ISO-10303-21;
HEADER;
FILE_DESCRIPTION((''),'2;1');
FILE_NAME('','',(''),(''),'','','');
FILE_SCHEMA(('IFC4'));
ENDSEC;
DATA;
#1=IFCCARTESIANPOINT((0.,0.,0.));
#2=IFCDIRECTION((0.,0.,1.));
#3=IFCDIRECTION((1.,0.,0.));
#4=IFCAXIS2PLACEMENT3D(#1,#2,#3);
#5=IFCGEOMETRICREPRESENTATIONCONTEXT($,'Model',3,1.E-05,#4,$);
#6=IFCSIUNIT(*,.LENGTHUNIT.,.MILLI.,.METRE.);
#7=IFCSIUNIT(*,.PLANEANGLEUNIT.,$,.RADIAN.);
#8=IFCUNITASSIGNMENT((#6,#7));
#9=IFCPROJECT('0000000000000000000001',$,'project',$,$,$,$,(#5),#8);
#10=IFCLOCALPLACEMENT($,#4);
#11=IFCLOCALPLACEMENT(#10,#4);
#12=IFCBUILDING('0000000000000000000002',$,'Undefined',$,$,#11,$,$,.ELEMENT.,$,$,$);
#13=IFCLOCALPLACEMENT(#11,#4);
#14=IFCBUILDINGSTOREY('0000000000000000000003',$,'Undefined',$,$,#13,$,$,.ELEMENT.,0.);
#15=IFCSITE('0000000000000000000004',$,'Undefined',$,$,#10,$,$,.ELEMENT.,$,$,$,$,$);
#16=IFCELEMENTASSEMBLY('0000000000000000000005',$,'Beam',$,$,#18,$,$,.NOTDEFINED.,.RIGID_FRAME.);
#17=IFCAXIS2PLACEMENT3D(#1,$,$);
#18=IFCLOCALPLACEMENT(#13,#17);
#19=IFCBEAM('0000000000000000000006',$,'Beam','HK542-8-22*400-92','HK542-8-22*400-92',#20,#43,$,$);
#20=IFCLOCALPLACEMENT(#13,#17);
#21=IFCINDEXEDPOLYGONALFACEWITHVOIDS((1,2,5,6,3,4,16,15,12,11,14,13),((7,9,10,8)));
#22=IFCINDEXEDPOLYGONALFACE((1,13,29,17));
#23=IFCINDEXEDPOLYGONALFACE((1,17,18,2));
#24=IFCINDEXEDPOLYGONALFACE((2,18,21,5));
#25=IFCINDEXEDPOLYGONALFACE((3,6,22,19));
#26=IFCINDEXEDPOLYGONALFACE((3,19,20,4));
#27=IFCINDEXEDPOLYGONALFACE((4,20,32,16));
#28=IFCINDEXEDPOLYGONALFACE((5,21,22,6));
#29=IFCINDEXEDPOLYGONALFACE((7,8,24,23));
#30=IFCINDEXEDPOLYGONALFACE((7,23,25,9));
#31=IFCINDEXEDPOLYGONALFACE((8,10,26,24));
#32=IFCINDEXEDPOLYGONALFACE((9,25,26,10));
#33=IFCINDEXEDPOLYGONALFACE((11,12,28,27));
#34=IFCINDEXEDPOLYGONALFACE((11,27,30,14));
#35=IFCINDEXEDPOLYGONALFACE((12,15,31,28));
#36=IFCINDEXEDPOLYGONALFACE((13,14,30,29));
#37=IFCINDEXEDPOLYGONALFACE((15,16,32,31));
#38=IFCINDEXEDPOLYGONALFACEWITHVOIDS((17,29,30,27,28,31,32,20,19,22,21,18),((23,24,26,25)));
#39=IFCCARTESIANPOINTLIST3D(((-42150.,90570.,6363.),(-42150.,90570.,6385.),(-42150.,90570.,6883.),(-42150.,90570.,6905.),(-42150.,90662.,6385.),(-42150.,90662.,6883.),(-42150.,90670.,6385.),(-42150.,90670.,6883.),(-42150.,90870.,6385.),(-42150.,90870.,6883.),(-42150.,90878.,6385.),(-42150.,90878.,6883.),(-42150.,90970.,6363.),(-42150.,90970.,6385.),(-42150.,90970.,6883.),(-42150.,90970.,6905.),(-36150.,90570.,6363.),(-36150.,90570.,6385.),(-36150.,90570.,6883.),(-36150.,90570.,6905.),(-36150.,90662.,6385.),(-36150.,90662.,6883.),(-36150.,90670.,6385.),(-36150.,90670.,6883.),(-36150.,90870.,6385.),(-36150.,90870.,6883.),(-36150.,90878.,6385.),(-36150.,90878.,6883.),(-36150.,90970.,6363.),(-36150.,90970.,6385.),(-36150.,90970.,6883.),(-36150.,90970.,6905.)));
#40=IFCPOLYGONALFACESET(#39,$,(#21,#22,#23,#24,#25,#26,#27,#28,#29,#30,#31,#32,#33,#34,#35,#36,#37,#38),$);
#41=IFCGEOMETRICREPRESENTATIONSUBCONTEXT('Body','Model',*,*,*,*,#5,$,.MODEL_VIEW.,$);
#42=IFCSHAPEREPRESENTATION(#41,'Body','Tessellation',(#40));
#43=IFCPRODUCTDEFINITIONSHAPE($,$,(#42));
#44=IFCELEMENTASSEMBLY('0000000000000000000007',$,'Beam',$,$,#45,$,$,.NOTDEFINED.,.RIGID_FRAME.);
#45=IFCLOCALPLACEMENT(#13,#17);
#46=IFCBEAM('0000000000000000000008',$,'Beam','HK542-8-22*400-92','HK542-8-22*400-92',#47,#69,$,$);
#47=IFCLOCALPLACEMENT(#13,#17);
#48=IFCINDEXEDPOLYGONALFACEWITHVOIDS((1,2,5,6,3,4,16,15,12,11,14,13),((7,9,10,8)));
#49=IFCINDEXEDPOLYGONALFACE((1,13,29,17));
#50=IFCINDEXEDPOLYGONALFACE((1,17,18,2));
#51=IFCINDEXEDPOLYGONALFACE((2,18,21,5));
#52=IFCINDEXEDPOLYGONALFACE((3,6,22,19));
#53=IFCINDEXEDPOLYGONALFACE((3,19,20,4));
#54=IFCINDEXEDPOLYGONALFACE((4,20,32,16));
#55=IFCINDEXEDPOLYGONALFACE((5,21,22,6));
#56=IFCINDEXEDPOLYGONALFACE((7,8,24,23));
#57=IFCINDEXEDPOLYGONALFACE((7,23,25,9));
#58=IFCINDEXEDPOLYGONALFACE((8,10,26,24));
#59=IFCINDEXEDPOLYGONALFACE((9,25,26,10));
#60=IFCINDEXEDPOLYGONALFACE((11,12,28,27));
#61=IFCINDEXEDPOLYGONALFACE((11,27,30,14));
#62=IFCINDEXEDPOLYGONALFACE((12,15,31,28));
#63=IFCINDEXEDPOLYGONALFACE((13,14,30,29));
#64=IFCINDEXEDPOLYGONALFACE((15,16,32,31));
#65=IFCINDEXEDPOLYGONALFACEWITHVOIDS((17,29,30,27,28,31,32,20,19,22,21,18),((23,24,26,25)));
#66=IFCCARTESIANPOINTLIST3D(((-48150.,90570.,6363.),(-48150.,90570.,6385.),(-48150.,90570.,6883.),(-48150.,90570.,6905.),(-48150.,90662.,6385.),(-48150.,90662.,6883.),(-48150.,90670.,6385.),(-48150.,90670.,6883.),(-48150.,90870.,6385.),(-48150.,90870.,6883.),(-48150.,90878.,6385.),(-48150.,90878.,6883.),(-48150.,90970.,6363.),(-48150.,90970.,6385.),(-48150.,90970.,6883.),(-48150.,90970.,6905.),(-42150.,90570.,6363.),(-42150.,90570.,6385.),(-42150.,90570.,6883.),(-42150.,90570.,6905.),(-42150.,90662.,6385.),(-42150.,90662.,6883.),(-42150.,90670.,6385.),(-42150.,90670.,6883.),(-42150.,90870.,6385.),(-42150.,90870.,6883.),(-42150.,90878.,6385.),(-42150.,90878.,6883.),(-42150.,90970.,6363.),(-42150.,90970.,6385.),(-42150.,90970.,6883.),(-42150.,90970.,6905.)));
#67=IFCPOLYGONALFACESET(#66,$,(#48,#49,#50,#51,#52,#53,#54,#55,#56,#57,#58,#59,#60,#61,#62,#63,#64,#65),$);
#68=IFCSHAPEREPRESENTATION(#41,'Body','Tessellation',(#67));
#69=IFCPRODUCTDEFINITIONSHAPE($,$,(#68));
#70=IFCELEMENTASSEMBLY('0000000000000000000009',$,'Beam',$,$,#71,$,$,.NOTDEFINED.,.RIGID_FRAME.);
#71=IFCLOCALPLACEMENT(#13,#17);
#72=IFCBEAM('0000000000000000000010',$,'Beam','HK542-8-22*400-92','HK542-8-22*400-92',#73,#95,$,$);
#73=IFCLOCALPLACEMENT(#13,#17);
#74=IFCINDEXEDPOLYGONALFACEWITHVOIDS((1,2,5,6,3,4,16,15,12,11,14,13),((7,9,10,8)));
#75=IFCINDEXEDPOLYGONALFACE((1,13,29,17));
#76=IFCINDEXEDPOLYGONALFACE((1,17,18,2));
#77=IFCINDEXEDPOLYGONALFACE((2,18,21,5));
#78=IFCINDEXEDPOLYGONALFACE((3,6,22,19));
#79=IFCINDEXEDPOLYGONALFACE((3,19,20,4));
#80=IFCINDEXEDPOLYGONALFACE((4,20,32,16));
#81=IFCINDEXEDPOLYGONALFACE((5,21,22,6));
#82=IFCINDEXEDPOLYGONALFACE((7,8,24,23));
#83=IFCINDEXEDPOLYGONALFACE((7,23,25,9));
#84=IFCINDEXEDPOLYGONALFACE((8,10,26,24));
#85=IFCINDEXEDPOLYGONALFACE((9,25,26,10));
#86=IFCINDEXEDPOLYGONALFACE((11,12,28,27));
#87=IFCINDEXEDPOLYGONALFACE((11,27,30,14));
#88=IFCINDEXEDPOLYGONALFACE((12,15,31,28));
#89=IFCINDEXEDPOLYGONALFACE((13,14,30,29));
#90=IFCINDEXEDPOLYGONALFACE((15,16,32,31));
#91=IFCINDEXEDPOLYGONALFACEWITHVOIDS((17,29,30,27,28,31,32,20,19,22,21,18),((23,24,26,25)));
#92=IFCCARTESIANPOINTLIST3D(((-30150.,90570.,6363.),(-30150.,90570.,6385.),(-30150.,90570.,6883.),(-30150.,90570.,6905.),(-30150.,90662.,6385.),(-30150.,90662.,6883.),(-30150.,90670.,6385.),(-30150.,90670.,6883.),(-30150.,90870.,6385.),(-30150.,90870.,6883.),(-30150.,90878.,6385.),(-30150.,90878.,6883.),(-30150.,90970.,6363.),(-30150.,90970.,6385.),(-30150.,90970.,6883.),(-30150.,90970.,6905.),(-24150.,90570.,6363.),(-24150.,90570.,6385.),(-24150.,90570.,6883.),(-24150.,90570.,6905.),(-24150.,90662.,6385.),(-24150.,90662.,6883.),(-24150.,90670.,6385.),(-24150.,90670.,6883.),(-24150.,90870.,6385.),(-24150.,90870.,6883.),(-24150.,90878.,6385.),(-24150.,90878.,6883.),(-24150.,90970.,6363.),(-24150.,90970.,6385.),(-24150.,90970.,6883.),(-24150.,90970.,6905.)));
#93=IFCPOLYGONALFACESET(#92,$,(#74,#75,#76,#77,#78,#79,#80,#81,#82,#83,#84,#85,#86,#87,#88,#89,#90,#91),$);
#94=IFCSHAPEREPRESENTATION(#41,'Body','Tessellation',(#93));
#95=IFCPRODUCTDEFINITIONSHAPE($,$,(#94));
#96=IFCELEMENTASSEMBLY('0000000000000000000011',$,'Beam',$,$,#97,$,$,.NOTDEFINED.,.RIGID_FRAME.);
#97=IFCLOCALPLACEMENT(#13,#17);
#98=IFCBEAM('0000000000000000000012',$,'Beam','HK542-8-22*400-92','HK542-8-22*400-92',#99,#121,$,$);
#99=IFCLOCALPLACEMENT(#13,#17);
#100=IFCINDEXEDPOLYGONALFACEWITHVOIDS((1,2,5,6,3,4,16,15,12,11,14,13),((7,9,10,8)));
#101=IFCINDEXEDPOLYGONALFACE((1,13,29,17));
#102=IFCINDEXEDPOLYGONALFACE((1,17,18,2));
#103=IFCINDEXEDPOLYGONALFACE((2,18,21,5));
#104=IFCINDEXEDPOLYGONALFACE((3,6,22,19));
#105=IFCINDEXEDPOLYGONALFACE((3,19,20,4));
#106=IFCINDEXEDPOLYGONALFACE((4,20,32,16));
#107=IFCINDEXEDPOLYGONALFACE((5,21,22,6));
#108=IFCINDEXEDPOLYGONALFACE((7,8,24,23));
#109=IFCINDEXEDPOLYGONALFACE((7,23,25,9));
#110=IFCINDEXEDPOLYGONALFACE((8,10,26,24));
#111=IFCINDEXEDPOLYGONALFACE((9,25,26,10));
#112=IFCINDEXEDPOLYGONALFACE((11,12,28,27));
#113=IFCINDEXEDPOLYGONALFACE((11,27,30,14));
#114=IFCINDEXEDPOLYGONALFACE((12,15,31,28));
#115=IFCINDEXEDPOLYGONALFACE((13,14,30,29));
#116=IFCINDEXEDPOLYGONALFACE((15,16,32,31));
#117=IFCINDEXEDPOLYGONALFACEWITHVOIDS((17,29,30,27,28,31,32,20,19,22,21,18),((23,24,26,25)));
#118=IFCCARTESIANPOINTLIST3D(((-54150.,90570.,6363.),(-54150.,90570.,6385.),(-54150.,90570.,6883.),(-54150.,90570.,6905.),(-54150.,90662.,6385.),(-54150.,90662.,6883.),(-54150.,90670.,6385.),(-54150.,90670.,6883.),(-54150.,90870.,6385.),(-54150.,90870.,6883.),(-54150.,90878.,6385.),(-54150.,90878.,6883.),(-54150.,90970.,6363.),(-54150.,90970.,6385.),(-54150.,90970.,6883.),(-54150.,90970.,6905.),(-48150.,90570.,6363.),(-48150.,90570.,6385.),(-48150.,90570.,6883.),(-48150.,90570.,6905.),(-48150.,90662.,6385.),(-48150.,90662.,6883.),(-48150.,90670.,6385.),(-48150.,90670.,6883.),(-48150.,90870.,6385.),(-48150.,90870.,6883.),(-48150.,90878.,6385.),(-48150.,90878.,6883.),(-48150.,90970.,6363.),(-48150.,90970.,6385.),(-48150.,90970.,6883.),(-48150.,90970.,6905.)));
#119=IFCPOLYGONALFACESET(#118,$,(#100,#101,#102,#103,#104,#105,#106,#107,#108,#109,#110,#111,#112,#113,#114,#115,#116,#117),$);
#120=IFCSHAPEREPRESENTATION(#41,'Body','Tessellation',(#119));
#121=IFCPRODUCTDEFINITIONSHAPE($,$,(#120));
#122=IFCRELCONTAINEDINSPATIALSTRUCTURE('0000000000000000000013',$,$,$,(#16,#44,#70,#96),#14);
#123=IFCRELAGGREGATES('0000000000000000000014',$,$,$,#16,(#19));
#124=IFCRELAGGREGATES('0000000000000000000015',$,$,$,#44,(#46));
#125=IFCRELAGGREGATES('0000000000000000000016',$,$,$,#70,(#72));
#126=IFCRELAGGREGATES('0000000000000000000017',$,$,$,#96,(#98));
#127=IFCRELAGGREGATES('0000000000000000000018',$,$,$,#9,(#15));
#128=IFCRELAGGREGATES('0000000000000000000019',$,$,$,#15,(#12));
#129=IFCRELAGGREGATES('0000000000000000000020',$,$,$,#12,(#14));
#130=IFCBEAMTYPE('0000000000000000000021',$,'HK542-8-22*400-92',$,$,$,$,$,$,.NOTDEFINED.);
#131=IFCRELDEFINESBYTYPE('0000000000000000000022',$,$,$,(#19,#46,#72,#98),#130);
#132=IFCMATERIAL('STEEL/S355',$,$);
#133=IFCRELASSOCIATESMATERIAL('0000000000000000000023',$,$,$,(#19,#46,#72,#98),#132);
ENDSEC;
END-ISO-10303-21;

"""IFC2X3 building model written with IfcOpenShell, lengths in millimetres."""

from ifc_helpers import new_model, si_unit, frame, origin_with_axes, place, context, subcontext, project, spatial, polyline, outline, extrude, material, type_object, element, aggregate, save


model = new_model("IFC2X3")

# Units and contexts
model_context = context("Model", 3, precision=1e-05, world=origin_with_axes())
body_context = subcontext(model_context, "Body", "Model", "MODEL_VIEW")
ifc_project = project(units=[si_unit("LENGTHUNIT", "METRE", prefix="MILLI"), si_unit("PLANEANGLEUNIT", "RADIAN")], contexts=[model_context])

# Site, building, storey
site_placement = place(None, origin_with_axes())
site = spatial("IfcSite", under=ifc_project, at=site_placement, Name="Undefined", CompositionType="ELEMENT")
building_placement = place(site_placement, origin_with_axes())
building = spatial("IfcBuilding", under=site, at=building_placement, Name="Undefined", CompositionType="ELEMENT")
storey_placement = place(building_placement, origin_with_axes())
storey = spatial("IfcBuildingStorey", under=building, at=storey_placement, Name="Undefined", CompositionType="ELEMENT", Elevation=0.0)

# Element assemblies, beams
ifc_material_1 = material(Name="STEEL/S355")
beam_type_1 = type_object("IfcBeamType", Name="HK542-8-22*400-92", PredefinedType="NOTDEFINED")
assembly_1_placement = place(storey_placement, origin_with_axes())
assembly_1 = element("IfcElementAssembly", 1, at=assembly_1_placement, inside=storey, Name="Beam", AssemblyPlace="NOTDEFINED", PredefinedType="RIGID_FRAME")
beam_1_placement = place(assembly_1_placement, frame((-36150.0, 90770.0, 6634.0), z_axis=(0.0, 0.0, 1.0), x_axis=(-1.0, 0.0, 0.0)))
beam_1 = element("IfcBeam", 2, at=beam_1_placement, type_object=beam_type_1, material=ifc_material_1, Name="Beam", Description="HK542-8-22*400-92", ObjectType="HK542-8-22*400-92", context=body_context, shape_type="SweptSolid", body=[
    extrude(outline(polyline([(-200.0, 249.0), (-200.0, 271.0), (200.0, 271.0), (200.0, 249.0), (108.0, 249.0), (108.0, -249.0), (200.0, -249.0), (200.0, -271.0), (-200.0, -271.0), (-200.0, -249.0), (-108.0, -249.0), (-108.0, 249.0), (-200.0, 249.0)]), holes=[polyline([(-100.0, -249.0), (100.0, -249.0), (100.0, 249.0), (-100.0, 249.0), (-100.0, -249.0)])]), frame((6000.0, 0.0, 0.0), z_axis=(-1.0, 0.0, 0.0), x_axis=(0.0, -1.0, 0.0)), (0.0, 0.0, 1.0), 6000.0),
])
aggregate(assembly_1, [beam_1])
assembly_2_placement = place(storey_placement, origin_with_axes())
assembly_2 = element("IfcElementAssembly", 3, at=assembly_2_placement, inside=storey, Name="Beam", AssemblyPlace="NOTDEFINED", PredefinedType="RIGID_FRAME")
beam_2_placement = place(assembly_2_placement, frame((-42150.0, 90770.0, 6634.0), z_axis=(0.0, 0.0, 1.0), x_axis=(-1.0, 0.0, 0.0)))
beam_2 = element("IfcBeam", 4, at=beam_2_placement, type_object=beam_type_1, material=ifc_material_1, Name="Beam", Description="HK542-8-22*400-92", ObjectType="HK542-8-22*400-92", context=body_context, shape_type="SweptSolid", body=[
    extrude(outline(polyline([(-200.0, 249.0), (-200.0, 271.0), (200.0, 271.0), (200.0, 249.0), (108.0, 249.0), (108.0, -249.0), (200.0, -249.0), (200.0, -271.0), (-200.0, -271.0), (-200.0, -249.0), (-108.0, -249.0), (-108.0, 249.0), (-200.0, 249.0)]), holes=[polyline([(-100.0, -249.0), (100.0, -249.0), (100.0, 249.0), (-100.0, 249.0), (-100.0, -249.0)])]), frame((6000.0, 0.0, 0.0), z_axis=(-1.0, 0.0, 0.0), x_axis=(0.0, -1.0, 0.0)), (0.0, 0.0, 1.0), 6000.0),
])
aggregate(assembly_2, [beam_2])
assembly_3_placement = place(storey_placement, origin_with_axes())
assembly_3 = element("IfcElementAssembly", 5, at=assembly_3_placement, inside=storey, Name="Beam", AssemblyPlace="NOTDEFINED", PredefinedType="RIGID_FRAME")
beam_3_placement = place(assembly_3_placement, frame((-24150.0, 90770.0, 6634.0), z_axis=(0.0, 0.0, 1.0), x_axis=(-1.0, 0.0, 0.0)))
beam_3 = element("IfcBeam", 6, at=beam_3_placement, type_object=beam_type_1, material=ifc_material_1, Name="Beam", Description="HK542-8-22*400-92", ObjectType="HK542-8-22*400-92", context=body_context, shape_type="SweptSolid", body=[
    extrude(outline(polyline([(-200.0, 249.0), (-200.0, 271.0), (200.0, 271.0), (200.0, 249.0), (108.0, 249.0), (108.0, -249.0), (200.0, -249.0), (200.0, -271.0), (-200.0, -271.0), (-200.0, -249.0), (-108.0, -249.0), (-108.0, 249.0), (-200.0, 249.0)]), holes=[polyline([(-100.0, -249.0), (100.0, -249.0), (100.0, 249.0), (-100.0, 249.0), (-100.0, -249.0)])]), frame((6000.0, 0.0, 0.0), z_axis=(-1.0, 0.0, 0.0), x_axis=(0.0, -1.0, 0.0)), (0.0, 0.0, 1.0), 6000.0),
])
aggregate(assembly_3, [beam_3])
assembly_4_placement = place(storey_placement, origin_with_axes())
assembly_4 = element("IfcElementAssembly", 7, at=assembly_4_placement, inside=storey, Name="Beam", AssemblyPlace="NOTDEFINED", PredefinedType="RIGID_FRAME")
beam_4_placement = place(assembly_4_placement, frame((-48150.0, 90770.0, 6634.0), z_axis=(0.0, 0.0, 1.0), x_axis=(-1.0, 0.0, 0.0)))
beam_4 = element("IfcBeam", 8, at=beam_4_placement, type_object=beam_type_1, material=ifc_material_1, Name="Beam", Description="HK542-8-22*400-92", ObjectType="HK542-8-22*400-92", context=body_context, shape_type="SweptSolid", body=[
    extrude(outline(polyline([(-200.0, 249.0), (-200.0, 271.0), (200.0, 271.0), (200.0, 249.0), (108.0, 249.0), (108.0, -249.0), (200.0, -249.0), (200.0, -271.0), (-200.0, -271.0), (-200.0, -249.0), (-108.0, -249.0), (-108.0, 249.0), (-200.0, 249.0)]), holes=[polyline([(-100.0, -249.0), (100.0, -249.0), (100.0, 249.0), (-100.0, 249.0), (-100.0, -249.0)])]), frame((6000.0, 0.0, 0.0), z_axis=(-1.0, 0.0, 0.0), x_axis=(0.0, -1.0, 0.0)), (0.0, 0.0, 1.0), 6000.0),
])
aggregate(assembly_4, [beam_4])

save(model, "model.ifc")
